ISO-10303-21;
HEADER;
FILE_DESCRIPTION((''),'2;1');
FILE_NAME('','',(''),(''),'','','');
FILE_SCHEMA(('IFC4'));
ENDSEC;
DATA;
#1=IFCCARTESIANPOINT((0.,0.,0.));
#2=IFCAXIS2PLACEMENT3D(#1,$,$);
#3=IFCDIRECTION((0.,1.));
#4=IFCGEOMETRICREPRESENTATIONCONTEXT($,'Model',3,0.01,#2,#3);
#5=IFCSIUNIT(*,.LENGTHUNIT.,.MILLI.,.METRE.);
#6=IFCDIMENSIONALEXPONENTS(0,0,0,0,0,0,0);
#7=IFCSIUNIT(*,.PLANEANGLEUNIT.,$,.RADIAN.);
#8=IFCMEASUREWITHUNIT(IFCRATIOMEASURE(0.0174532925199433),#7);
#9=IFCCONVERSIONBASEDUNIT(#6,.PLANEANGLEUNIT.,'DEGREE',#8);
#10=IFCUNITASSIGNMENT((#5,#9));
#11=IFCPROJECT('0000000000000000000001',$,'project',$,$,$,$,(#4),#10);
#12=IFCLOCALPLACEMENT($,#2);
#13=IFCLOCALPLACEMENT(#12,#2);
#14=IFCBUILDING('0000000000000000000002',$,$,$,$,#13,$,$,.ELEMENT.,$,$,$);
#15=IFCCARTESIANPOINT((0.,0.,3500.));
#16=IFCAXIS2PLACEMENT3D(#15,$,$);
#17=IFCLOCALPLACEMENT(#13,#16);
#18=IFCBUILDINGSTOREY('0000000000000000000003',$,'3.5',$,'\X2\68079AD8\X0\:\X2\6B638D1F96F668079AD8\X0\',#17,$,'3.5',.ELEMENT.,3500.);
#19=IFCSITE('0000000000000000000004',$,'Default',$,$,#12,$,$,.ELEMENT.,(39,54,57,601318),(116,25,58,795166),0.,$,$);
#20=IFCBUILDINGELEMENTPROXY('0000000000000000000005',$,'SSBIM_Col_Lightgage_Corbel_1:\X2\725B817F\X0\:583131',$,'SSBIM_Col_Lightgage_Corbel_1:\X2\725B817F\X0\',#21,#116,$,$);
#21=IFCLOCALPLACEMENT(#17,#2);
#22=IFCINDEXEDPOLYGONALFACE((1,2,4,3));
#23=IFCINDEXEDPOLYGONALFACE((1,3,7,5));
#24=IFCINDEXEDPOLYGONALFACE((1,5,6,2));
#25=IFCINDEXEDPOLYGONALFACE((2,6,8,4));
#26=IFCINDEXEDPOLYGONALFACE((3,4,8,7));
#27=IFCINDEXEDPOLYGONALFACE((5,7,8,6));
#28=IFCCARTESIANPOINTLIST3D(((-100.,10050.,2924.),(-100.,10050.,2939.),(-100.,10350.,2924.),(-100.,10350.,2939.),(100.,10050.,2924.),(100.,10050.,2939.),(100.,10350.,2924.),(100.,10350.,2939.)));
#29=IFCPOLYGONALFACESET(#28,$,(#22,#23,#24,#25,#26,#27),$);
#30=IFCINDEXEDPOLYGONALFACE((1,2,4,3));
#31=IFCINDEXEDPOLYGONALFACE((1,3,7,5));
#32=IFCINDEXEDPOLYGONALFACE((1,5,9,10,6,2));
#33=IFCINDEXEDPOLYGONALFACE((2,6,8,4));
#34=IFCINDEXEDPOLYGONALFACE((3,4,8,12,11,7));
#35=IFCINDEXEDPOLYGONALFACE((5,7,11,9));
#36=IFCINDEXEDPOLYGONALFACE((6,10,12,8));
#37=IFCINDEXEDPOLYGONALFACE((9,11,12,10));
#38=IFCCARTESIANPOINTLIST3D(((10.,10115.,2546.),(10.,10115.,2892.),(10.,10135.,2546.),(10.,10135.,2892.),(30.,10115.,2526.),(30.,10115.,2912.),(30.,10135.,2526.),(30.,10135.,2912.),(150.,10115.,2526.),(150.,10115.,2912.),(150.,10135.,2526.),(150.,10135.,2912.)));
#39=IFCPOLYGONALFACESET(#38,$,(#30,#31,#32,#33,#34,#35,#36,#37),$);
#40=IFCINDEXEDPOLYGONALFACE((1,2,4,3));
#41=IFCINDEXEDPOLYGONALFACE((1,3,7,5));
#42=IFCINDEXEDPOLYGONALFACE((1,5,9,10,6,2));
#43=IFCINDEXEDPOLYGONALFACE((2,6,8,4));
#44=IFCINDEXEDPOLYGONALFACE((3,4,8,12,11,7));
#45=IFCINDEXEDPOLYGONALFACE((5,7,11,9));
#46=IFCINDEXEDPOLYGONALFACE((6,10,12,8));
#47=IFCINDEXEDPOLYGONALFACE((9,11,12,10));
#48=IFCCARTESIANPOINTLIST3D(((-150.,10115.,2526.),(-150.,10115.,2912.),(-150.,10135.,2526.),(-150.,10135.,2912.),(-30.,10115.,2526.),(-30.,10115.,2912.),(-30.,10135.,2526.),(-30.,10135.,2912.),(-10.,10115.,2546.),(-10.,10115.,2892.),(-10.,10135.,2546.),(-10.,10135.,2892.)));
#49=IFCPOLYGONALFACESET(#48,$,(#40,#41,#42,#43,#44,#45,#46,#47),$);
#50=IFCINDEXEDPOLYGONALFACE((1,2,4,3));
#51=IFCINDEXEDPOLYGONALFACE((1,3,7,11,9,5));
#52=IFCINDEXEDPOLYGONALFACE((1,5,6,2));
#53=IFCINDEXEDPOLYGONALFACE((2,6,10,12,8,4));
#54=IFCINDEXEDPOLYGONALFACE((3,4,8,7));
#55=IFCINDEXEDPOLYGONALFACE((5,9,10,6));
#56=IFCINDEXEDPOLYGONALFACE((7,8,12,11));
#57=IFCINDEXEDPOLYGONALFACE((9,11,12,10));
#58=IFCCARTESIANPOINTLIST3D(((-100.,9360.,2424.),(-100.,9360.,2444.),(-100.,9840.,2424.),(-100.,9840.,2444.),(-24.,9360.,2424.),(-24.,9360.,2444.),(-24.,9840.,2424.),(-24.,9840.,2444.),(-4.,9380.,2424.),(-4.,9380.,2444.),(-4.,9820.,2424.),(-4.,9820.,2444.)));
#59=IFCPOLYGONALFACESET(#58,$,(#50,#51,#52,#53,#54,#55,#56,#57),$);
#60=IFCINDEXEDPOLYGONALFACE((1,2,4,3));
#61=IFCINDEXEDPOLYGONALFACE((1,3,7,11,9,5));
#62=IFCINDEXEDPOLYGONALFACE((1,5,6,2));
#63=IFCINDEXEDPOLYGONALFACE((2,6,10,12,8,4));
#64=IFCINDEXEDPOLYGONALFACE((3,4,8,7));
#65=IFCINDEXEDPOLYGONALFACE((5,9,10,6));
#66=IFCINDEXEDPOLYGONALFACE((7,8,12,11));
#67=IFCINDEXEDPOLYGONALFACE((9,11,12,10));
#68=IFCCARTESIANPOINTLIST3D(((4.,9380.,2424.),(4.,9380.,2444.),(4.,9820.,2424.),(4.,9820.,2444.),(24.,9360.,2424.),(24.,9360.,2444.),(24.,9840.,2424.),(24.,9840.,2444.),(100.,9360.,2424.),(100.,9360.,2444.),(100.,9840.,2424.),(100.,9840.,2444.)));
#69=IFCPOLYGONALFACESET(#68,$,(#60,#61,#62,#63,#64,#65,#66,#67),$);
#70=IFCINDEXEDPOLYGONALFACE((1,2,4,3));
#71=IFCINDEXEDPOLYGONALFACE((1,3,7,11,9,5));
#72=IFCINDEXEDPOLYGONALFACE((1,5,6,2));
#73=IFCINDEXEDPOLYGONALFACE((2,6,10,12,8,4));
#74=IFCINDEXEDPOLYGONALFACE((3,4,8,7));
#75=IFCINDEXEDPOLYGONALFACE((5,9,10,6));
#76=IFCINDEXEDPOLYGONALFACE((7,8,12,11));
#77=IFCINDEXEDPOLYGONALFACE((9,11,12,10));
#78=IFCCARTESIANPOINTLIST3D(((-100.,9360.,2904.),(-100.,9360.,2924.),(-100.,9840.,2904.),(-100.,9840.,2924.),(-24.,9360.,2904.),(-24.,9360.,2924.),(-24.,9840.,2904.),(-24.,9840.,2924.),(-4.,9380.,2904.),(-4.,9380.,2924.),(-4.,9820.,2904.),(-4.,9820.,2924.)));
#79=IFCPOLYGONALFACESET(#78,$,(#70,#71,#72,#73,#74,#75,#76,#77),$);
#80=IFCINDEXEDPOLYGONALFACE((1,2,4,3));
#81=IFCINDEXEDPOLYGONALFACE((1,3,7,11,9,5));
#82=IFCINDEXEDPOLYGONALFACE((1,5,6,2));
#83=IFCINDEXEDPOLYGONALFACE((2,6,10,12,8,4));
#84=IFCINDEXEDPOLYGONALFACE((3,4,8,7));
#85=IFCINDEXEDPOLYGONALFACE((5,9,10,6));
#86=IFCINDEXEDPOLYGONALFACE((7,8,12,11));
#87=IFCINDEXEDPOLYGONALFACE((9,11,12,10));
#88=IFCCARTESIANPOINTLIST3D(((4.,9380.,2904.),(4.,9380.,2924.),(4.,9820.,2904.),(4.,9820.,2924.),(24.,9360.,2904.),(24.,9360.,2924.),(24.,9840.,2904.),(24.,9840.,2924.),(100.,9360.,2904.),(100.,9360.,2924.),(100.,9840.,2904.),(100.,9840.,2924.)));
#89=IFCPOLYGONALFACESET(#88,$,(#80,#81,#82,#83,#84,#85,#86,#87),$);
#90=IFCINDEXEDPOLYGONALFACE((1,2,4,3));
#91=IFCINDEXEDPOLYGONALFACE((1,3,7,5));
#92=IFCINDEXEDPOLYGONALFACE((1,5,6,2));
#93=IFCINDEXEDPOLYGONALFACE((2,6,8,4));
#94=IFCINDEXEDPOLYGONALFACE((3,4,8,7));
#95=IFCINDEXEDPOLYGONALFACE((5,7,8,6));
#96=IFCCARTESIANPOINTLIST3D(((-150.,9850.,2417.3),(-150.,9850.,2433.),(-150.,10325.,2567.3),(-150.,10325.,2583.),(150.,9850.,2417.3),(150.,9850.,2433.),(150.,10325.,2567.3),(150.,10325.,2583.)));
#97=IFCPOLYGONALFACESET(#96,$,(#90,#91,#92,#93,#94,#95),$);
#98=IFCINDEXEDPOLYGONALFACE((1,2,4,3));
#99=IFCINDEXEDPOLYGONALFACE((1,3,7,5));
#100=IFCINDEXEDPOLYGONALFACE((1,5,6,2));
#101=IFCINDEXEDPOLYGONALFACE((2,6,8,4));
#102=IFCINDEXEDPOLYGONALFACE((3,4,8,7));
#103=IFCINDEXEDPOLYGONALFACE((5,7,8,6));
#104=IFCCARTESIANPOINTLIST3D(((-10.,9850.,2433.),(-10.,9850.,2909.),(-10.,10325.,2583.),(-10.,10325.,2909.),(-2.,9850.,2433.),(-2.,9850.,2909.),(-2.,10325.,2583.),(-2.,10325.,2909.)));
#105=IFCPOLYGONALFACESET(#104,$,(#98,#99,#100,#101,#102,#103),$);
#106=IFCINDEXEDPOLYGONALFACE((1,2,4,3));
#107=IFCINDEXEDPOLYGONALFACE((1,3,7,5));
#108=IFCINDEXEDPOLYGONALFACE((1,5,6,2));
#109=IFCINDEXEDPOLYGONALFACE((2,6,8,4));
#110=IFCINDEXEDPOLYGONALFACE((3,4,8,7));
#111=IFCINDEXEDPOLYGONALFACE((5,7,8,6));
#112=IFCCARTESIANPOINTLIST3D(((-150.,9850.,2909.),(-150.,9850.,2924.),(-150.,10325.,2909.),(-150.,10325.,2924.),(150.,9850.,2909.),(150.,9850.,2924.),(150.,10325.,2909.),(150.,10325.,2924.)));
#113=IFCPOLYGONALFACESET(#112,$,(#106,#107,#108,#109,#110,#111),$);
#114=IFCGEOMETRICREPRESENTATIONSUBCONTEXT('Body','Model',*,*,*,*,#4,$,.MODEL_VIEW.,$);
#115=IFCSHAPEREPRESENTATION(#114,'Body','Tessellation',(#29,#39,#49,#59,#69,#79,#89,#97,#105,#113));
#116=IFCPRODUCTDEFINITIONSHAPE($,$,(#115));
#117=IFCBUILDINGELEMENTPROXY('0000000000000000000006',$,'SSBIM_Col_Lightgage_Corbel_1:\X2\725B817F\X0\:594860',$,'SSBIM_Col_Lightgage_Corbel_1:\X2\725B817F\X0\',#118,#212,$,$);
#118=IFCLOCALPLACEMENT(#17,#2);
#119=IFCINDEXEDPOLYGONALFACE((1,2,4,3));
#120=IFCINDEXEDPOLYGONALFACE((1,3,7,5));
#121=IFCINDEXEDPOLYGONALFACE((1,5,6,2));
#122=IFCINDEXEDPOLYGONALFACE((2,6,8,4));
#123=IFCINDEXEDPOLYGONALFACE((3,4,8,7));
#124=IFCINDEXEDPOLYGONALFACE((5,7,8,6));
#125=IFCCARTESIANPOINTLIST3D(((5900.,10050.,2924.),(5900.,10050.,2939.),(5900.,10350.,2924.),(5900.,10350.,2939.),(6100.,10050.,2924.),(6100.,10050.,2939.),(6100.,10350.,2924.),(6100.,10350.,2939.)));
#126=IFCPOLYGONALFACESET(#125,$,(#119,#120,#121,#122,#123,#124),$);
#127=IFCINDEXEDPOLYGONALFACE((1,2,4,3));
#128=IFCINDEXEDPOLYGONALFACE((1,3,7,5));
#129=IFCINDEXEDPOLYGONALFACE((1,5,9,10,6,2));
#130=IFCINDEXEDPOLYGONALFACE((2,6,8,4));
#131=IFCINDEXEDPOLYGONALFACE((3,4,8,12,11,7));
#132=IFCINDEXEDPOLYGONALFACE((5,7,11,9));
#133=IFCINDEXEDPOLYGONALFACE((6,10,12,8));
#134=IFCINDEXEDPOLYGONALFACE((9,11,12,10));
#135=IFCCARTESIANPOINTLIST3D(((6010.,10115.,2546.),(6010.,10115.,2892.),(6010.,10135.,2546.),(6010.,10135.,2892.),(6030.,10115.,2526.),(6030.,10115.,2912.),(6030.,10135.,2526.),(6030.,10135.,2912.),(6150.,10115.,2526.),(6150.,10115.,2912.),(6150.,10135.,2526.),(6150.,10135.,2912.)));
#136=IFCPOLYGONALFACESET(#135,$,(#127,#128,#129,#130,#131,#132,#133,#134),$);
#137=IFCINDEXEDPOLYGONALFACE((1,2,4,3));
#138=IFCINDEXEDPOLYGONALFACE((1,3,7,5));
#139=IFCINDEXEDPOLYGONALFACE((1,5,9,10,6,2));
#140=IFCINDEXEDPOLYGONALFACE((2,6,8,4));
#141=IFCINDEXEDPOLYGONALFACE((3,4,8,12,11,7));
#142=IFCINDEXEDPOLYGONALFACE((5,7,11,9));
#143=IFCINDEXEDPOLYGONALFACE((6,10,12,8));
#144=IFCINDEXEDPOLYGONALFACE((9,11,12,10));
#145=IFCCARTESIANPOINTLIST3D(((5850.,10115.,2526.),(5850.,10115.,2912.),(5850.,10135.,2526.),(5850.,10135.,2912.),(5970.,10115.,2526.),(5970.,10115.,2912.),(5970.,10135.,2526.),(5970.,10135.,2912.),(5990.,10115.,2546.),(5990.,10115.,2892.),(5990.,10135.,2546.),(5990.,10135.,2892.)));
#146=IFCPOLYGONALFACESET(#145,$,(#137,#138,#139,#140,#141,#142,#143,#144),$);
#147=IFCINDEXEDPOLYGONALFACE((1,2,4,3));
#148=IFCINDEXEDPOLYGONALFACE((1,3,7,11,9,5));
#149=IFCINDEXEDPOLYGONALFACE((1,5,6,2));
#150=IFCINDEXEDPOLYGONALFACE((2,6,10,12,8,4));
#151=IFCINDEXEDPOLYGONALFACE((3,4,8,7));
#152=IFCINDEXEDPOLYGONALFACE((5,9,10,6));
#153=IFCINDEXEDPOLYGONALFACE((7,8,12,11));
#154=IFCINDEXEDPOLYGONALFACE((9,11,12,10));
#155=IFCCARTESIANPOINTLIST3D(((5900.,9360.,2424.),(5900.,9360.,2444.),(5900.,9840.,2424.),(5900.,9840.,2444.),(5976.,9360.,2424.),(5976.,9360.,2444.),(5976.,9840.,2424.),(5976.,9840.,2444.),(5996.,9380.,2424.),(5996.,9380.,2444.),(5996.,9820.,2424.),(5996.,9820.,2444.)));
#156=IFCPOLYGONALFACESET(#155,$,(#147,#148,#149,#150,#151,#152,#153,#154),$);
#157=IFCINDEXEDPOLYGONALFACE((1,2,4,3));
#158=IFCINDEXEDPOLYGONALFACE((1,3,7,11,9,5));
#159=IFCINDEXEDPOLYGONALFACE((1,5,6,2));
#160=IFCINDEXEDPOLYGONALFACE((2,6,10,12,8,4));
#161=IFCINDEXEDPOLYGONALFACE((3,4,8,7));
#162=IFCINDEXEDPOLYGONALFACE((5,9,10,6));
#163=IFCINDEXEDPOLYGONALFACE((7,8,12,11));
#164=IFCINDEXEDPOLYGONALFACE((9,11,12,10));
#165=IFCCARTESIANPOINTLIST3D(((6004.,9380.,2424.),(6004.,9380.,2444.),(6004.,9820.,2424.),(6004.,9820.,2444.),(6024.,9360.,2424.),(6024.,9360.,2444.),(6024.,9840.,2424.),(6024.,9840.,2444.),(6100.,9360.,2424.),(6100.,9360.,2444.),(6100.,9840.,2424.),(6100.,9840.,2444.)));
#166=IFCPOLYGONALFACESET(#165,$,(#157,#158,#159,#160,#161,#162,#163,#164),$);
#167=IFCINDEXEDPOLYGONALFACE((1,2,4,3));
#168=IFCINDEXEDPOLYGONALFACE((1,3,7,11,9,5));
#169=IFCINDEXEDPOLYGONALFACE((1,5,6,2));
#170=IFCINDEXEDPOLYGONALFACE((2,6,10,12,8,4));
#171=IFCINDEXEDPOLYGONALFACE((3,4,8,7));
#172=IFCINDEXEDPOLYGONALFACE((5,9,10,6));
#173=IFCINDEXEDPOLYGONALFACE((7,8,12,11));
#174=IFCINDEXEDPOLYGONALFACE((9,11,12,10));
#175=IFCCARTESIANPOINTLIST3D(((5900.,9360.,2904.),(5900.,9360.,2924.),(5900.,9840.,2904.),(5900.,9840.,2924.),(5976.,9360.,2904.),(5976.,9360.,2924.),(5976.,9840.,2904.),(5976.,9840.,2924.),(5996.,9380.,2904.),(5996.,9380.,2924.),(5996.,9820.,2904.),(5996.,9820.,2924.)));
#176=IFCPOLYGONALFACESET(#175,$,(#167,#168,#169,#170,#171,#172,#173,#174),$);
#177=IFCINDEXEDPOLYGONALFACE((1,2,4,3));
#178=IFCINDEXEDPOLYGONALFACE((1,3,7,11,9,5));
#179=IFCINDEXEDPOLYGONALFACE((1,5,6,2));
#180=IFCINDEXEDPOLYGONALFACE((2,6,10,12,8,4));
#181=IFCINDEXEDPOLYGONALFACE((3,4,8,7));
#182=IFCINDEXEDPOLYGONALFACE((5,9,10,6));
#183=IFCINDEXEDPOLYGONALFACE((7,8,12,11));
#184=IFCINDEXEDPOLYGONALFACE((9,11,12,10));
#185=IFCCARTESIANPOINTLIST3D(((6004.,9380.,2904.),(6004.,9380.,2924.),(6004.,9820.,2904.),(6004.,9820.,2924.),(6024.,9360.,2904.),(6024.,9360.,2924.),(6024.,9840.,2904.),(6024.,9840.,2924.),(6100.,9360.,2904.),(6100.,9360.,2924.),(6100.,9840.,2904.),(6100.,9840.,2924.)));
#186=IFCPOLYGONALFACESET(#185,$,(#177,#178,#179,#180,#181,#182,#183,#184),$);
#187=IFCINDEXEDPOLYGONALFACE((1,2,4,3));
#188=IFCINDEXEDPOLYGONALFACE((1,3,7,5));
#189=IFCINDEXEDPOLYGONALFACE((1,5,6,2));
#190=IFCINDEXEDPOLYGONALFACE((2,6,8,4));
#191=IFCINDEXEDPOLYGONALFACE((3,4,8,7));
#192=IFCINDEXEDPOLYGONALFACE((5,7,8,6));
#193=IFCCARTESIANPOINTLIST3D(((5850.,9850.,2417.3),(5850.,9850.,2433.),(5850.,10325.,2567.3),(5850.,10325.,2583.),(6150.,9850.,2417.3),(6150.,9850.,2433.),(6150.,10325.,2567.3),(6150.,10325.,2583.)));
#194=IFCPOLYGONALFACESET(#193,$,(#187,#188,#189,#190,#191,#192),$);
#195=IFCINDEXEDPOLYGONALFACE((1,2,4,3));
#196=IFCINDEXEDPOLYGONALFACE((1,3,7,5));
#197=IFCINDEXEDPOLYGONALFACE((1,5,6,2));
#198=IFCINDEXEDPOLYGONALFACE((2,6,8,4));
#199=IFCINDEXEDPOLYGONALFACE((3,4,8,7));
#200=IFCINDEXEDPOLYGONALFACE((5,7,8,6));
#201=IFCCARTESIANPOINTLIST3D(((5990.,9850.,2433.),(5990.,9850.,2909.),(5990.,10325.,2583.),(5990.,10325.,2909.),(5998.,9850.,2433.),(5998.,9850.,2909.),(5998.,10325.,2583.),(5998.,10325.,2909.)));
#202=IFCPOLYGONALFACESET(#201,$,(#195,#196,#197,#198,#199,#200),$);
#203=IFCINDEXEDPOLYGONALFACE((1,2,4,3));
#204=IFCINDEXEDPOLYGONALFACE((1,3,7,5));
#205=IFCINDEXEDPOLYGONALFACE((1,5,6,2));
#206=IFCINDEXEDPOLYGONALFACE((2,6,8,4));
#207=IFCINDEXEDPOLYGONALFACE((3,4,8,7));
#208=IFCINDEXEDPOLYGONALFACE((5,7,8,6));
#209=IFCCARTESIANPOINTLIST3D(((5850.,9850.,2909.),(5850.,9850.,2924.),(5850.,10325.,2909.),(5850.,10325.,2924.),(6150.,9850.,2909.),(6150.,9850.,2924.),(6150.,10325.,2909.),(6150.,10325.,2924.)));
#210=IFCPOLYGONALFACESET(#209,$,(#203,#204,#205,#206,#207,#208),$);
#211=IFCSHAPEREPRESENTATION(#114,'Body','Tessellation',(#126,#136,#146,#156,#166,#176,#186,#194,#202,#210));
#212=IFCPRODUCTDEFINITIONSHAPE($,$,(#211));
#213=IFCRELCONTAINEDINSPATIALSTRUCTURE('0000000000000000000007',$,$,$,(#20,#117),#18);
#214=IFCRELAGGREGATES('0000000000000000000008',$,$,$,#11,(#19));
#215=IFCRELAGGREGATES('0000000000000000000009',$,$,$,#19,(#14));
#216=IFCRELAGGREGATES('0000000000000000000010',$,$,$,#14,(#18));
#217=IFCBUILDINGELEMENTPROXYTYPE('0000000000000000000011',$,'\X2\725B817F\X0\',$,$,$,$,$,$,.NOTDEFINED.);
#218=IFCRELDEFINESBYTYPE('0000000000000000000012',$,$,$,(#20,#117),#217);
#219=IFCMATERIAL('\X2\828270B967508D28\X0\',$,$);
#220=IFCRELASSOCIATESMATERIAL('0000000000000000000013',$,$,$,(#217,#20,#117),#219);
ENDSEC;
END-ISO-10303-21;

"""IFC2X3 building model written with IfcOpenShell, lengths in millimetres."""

from ifc_helpers import new_model, entity, si_unit, converted_unit, direction, frame, frame_2d, origin, origin_2d_with_axis, place, context, subcontext, project, spatial, polyline, rectangle, outline, extrude, source, transform, mapped, material, type_object, type_shapes, element, save


model = new_model("IFC2X3")

# Units and contexts
model_context = context("Model", 3, precision=0.01, world=origin(), true_north=direction((0.0, 1.0)))
body_context = subcontext(model_context, "Body", "Model", "MODEL_VIEW")
ifc_project = project(units=[si_unit("LENGTHUNIT", "METRE", prefix="MILLI"), converted_unit("PLANEANGLEUNIT", "DEGREE", entity("IfcRatioMeasure", 0.0174532925199433), si_unit("PLANEANGLEUNIT", "RADIAN"), dimensions=[0, 0, 0, 0, 0, 0, 0])], contexts=[model_context])

# Site, building, storey
site_placement = place(None, origin())
site = spatial("IfcSite", under=ifc_project, at=site_placement, Name="Default", CompositionType="ELEMENT", RefLatitude=(39, 54, 57, 601318), RefLongitude=(116, 25, 58, 795166), RefElevation=0.0)
building_placement = place(site_placement, origin())
building = spatial("IfcBuilding", under=site, at=building_placement, CompositionType="ELEMENT")
storey_placement = place(building_placement, frame((0.0, 0.0, 3500.0)))
storey = spatial("IfcBuildingStorey", under=building, at=storey_placement, Name="3.5", ObjectType="标高:正负零标高", LongName="3.5", CompositionType="ELEMENT", Elevation=3500.0)

# Building element proxies
ifc_material_1 = material(Name="节点材质")
building_element_proxy_type_1 = type_object("IfcBuildingElementProxyType", Name="牛腿", PredefinedType="NOTDEFINED", material=ifc_material_1)
shared_shape_1 = source(origin(), body_context, "Body", "SweptSolid", [
    extrude(rectangle(XDim=200.0, YDim=300.0, at=frame_2d((0.0, 0.0), x_axis=(1.0, 0.0))), frame((636.4, 0.0, 0.0), z_axis=(0.0, 0.0, 1.0), x_axis=(0.0, -1.0, 0.0)), (0.0, 0.0, 1.0), 15.0),
    extrude(outline(polyline([(-86.7, -193.0), (33.3, -193.0), (53.3, -173.0), (53.3, 173.0), (33.3, 193.0), (-86.7, 193.0), (-86.7, -193.0)])), frame((551.4, -63.3, -205.0), z_axis=(1.0, 0.0, 0.0), x_axis=(0.0, 1.0, 0.0)), (0.0, 0.0, 1.0), 20.0),
    extrude(outline(polyline([(-193.0, -86.7), (193.0, -86.7), (193.0, 33.3), (173.0, 53.3), (-173.0, 53.3), (-193.0, 33.3), (-193.0, -86.7)])), frame((551.4, 63.3, -205.0), z_axis=(1.0, 0.0, 0.0), x_axis=(0.0, 0.0, 1.0)), (0.0, 0.0, 1.0), 20.0),
    extrude(outline(polyline([(-57.3, -240.0), (18.7, -240.0), (38.7, -220.0), (38.7, 220.0), (18.7, 240.0), (-57.3, 240.0), (-57.3, -240.0)])), frame((36.4, 42.7, -500.0), z_axis=(0.0, 0.0, 1.0), x_axis=(0.0, -1.0, 0.0)), (0.0, 0.0, 1.0), 20.0),
    extrude(outline(polyline([(-240.0, -57.3), (240.0, -57.3), (240.0, 18.7), (220.0, 38.7), (-220.0, 38.7), (-240.0, 18.7), (-240.0, -57.3)])), frame((36.4, -42.7, -500.0)), (0.0, 0.0, 1.0), 20.0),
    extrude(outline(polyline([(-57.3, -240.0), (18.7, -240.0), (38.7, -220.0), (38.7, 220.0), (18.7, 240.0), (-57.3, 240.0), (-57.3, -240.0)])), frame((36.4, 42.7, -20.0), z_axis=(0.0, 0.0, 1.0), x_axis=(0.0, -1.0, 0.0)), (0.0, 0.0, 1.0), 20.0),
    extrude(outline(polyline([(-240.0, -57.3), (240.0, -57.3), (240.0, 18.7), (220.0, 38.7), (-220.0, 38.7), (-240.0, 18.7), (-240.0, -57.3)])), frame((36.4, -42.7, -20.0)), (0.0, 0.0, 1.0), 20.0),
    extrude(outline(polyline([(-82.9, -237.5), (-67.1, -237.5), (82.9, 237.5), (67.1, 237.5), (-82.9, -237.5)])), frame((523.9, -150.0, -423.9), z_axis=(0.0, 1.0, 0.0), x_axis=(0.0, 0.0, 1.0)), (0.0, 0.0, 1.0), 300.0),
    extrude(outline(polyline([(-237.5, -200.5), (237.5, -200.5), (237.5, 125.5), (-237.5, 275.5), (-237.5, -200.5)])), frame((523.9, 2.0, -215.5), z_axis=(0.0, 1.0, 0.0), x_axis=(1.0, 0.0, 0.0)), (0.0, 0.0, 1.0), 8.0),
    extrude(rectangle(XDim=300.0, YDim=475.0, at=origin_2d_with_axis()), frame((523.9, 0.0, -15.0), z_axis=(0.0, 0.0, 1.0), x_axis=(0.0, -1.0, 0.0)), (0.0, 0.0, 1.0), 15.0),
])
type_shapes(building_element_proxy_type_1, [shared_shape_1])
for number, where, z_axis, x_axis, name in (
    (1, (0.0, 9563.6, 2924.0), (0.0, 0.0, 1.0), (0.0, 1.0, 0.0), "SSBIM_Col_Lightgage_Corbel_1:牛腿:583131"),
    (2, (6000.0, 9563.6, 2924.0), (0.0, 0.0, 1.0), (0.0, 1.0, 0.0), "SSBIM_Col_Lightgage_Corbel_1:牛腿:594860"),
):
    element("IfcBuildingElementProxy", number, at=place(storey_placement, frame(where, z_axis=z_axis, x_axis=x_axis)), inside=storey, type_object=building_element_proxy_type_1, material=ifc_material_1, Name=name, ObjectType="SSBIM_Col_Lightgage_Corbel_1:牛腿", context=body_context, shape_type="MappedRepresentation", body=[
        mapped(shared_shape_1, transform((0.0, 0.0, 0.0), scale=1.0)),
    ])

save(model, "model.ifc")
